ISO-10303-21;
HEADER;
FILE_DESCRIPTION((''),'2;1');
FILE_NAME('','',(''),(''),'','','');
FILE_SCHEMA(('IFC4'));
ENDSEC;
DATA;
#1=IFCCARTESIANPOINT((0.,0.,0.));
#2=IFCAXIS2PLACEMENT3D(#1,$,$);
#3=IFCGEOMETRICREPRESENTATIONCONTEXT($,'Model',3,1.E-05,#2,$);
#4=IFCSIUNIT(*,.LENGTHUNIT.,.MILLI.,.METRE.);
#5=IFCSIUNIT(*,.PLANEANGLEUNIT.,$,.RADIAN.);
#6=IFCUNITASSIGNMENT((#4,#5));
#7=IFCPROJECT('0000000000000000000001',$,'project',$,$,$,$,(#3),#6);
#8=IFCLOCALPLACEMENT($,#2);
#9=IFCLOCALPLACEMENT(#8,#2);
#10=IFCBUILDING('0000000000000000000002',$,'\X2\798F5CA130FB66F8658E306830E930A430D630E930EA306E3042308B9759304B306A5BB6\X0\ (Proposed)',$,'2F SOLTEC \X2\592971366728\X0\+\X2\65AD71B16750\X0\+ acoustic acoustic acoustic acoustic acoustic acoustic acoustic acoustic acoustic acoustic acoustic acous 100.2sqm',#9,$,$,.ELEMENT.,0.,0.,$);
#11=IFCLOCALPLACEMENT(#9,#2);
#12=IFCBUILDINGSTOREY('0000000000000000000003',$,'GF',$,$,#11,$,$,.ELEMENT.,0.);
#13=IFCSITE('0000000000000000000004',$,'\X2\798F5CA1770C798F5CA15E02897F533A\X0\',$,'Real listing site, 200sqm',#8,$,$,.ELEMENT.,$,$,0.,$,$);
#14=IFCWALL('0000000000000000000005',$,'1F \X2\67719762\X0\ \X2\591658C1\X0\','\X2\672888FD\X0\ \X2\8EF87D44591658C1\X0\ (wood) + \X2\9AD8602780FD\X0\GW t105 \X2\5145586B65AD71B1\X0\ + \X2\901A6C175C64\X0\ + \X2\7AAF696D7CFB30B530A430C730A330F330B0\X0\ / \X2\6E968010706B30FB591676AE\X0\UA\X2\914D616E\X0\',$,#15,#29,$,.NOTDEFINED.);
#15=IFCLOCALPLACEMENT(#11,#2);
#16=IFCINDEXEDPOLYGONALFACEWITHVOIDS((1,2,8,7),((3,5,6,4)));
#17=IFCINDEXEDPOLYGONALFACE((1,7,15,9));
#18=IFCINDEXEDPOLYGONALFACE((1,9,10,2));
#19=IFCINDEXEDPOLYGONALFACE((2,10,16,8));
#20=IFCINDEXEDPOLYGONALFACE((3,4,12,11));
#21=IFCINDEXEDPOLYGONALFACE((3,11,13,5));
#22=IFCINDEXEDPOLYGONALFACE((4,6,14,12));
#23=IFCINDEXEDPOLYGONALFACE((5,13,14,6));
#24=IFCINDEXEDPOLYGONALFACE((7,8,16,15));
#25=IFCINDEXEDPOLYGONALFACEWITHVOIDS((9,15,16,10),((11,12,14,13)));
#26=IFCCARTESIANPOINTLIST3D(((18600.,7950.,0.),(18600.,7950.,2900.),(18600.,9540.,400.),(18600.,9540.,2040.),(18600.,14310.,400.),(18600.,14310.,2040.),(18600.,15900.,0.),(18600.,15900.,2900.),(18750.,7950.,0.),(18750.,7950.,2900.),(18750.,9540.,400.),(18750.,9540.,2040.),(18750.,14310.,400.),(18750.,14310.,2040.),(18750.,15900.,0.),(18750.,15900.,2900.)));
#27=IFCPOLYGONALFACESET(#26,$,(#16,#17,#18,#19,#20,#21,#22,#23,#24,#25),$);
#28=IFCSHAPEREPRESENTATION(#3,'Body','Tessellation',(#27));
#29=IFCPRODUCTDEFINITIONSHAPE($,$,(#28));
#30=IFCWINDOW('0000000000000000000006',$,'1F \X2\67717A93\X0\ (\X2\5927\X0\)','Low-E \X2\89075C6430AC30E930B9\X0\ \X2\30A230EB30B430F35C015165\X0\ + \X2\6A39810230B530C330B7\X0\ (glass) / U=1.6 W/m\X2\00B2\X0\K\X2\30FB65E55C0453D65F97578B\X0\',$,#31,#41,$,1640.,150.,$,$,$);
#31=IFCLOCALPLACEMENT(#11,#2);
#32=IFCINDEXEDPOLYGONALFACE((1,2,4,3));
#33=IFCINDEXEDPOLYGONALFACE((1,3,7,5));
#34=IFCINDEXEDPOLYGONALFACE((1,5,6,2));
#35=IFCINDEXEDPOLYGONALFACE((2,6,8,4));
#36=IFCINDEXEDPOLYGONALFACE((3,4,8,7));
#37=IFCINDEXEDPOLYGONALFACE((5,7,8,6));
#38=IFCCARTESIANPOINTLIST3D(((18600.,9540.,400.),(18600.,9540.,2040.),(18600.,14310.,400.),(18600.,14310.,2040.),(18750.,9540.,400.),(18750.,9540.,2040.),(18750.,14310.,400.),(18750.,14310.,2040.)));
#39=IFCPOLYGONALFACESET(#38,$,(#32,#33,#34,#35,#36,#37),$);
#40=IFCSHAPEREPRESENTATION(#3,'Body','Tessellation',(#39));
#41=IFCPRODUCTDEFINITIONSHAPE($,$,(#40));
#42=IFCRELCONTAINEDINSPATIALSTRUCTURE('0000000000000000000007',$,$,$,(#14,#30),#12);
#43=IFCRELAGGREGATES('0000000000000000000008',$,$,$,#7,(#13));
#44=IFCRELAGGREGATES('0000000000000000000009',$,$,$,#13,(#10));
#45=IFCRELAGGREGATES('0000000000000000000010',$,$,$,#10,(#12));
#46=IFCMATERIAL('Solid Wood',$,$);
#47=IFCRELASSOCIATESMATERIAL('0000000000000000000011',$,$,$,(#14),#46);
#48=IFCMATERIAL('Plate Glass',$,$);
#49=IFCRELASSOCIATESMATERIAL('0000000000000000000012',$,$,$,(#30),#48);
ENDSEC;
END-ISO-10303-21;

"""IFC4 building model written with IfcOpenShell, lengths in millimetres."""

from ifc_helpers import new_model, si_unit, frame, frame_2d, origin, place, context, project, spatial, rectangle, extrude, material, element, fill, save


model = new_model("IFC4")

# Units and contexts
model_context = context("Model", 3, precision=1e-05, world=origin())
ifc_project = project(units=[si_unit("LENGTHUNIT", "METRE", prefix="MILLI"), si_unit("PLANEANGLEUNIT", "RADIAN")], contexts=[model_context])

# Site, building, storey
site_placement = place(None, origin())
site = spatial("IfcSite", under=ifc_project, at=site_placement, Name="福岡県福岡市西区", ObjectType="Real listing site, 200sqm", CompositionType="ELEMENT", RefElevation=0.0)
building_placement = place(site_placement, origin())
building = spatial("IfcBuilding", under=site, at=building_placement, Name="福岡・書斎とライブラリのある静かな家 (Proposed)", ObjectType="2F SOLTEC 天然木+断熱材+ acoustic acoustic acoustic acoustic acoustic acoustic acoustic acoustic acoustic acoustic acoustic acous 100.2sqm", CompositionType="ELEMENT", ElevationOfRefHeight=0.0, ElevationOfTerrain=0.0)
storey_placement = place(building_placement, origin())
storey = spatial("IfcBuildingStorey", under=building, at=storey_placement, Name="GF", CompositionType="ELEMENT", Elevation=0.0)

# Shared definitions
ifc_material_1 = material(Name="Solid Wood")

# Wall, opening, window
wall_1_placement = place(storey_placement, frame((9300.0, 3975.0, 0.0)))
wall_1 = element("IfcWall", 1, at=wall_1_placement, inside=storey, material=ifc_material_1, Name="1F 東面 外壁", Description="木製 軸組外壁 (wood) + 高性能GW t105 充填断熱 + 通気層 + 窯業系サイディング / 準耐火・外皮UA配慮", PredefinedType="NOTDEFINED", context=model_context, shape_type="SweptSolid", body=[
    extrude(rectangle(XDim=150.0, YDim=7950.0, at=frame_2d((75.0, 3975.0))), frame((9300.0, 3975.0, 0.0)), (0.0, 0.0, 1.0), 2900.0),
])
opening_1_placement = place(storey_placement, frame((9300.0, 4770.0, 200.0)))
opening_1 = element("IfcOpeningElement", 2, at=opening_1_placement, cuts=wall_1, PredefinedType="NOTDEFINED", context=model_context, shape_type="SweptSolid", body=[
    extrude(rectangle(XDim=150.0, YDim=4770.0, at=frame_2d((75.0, 2385.0))), frame((9300.0, 4770.0, 200.0)), (0.0, 0.0, 1.0), 1640.0),
])
ifc_material_2 = material(Name="Plate Glass")
window_1_placement = place(storey_placement, frame((9300.0, 4770.0, 200.0)))
window_1 = element("IfcWindow", 3, at=window_1_placement, inside=storey, material=ifc_material_2, Name="1F 東窓 (大)", Description="Low-E 複層ガラス アルゴン封入 + 樹脂サッシ (glass) / U=1.6 W/m²K・日射取得型", OverallHeight=1640.0, OverallWidth=150.0, context=model_context, shape_type="SweptSolid", body=[
    extrude(rectangle(XDim=150.0, YDim=4770.0, at=frame_2d((75.0, 2385.0))), frame((9300.0, 4770.0, 200.0)), (0.0, 0.0, 1.0), 1640.0),
])
fill(opening_1, window_1)

save(model, "model.ifc")
